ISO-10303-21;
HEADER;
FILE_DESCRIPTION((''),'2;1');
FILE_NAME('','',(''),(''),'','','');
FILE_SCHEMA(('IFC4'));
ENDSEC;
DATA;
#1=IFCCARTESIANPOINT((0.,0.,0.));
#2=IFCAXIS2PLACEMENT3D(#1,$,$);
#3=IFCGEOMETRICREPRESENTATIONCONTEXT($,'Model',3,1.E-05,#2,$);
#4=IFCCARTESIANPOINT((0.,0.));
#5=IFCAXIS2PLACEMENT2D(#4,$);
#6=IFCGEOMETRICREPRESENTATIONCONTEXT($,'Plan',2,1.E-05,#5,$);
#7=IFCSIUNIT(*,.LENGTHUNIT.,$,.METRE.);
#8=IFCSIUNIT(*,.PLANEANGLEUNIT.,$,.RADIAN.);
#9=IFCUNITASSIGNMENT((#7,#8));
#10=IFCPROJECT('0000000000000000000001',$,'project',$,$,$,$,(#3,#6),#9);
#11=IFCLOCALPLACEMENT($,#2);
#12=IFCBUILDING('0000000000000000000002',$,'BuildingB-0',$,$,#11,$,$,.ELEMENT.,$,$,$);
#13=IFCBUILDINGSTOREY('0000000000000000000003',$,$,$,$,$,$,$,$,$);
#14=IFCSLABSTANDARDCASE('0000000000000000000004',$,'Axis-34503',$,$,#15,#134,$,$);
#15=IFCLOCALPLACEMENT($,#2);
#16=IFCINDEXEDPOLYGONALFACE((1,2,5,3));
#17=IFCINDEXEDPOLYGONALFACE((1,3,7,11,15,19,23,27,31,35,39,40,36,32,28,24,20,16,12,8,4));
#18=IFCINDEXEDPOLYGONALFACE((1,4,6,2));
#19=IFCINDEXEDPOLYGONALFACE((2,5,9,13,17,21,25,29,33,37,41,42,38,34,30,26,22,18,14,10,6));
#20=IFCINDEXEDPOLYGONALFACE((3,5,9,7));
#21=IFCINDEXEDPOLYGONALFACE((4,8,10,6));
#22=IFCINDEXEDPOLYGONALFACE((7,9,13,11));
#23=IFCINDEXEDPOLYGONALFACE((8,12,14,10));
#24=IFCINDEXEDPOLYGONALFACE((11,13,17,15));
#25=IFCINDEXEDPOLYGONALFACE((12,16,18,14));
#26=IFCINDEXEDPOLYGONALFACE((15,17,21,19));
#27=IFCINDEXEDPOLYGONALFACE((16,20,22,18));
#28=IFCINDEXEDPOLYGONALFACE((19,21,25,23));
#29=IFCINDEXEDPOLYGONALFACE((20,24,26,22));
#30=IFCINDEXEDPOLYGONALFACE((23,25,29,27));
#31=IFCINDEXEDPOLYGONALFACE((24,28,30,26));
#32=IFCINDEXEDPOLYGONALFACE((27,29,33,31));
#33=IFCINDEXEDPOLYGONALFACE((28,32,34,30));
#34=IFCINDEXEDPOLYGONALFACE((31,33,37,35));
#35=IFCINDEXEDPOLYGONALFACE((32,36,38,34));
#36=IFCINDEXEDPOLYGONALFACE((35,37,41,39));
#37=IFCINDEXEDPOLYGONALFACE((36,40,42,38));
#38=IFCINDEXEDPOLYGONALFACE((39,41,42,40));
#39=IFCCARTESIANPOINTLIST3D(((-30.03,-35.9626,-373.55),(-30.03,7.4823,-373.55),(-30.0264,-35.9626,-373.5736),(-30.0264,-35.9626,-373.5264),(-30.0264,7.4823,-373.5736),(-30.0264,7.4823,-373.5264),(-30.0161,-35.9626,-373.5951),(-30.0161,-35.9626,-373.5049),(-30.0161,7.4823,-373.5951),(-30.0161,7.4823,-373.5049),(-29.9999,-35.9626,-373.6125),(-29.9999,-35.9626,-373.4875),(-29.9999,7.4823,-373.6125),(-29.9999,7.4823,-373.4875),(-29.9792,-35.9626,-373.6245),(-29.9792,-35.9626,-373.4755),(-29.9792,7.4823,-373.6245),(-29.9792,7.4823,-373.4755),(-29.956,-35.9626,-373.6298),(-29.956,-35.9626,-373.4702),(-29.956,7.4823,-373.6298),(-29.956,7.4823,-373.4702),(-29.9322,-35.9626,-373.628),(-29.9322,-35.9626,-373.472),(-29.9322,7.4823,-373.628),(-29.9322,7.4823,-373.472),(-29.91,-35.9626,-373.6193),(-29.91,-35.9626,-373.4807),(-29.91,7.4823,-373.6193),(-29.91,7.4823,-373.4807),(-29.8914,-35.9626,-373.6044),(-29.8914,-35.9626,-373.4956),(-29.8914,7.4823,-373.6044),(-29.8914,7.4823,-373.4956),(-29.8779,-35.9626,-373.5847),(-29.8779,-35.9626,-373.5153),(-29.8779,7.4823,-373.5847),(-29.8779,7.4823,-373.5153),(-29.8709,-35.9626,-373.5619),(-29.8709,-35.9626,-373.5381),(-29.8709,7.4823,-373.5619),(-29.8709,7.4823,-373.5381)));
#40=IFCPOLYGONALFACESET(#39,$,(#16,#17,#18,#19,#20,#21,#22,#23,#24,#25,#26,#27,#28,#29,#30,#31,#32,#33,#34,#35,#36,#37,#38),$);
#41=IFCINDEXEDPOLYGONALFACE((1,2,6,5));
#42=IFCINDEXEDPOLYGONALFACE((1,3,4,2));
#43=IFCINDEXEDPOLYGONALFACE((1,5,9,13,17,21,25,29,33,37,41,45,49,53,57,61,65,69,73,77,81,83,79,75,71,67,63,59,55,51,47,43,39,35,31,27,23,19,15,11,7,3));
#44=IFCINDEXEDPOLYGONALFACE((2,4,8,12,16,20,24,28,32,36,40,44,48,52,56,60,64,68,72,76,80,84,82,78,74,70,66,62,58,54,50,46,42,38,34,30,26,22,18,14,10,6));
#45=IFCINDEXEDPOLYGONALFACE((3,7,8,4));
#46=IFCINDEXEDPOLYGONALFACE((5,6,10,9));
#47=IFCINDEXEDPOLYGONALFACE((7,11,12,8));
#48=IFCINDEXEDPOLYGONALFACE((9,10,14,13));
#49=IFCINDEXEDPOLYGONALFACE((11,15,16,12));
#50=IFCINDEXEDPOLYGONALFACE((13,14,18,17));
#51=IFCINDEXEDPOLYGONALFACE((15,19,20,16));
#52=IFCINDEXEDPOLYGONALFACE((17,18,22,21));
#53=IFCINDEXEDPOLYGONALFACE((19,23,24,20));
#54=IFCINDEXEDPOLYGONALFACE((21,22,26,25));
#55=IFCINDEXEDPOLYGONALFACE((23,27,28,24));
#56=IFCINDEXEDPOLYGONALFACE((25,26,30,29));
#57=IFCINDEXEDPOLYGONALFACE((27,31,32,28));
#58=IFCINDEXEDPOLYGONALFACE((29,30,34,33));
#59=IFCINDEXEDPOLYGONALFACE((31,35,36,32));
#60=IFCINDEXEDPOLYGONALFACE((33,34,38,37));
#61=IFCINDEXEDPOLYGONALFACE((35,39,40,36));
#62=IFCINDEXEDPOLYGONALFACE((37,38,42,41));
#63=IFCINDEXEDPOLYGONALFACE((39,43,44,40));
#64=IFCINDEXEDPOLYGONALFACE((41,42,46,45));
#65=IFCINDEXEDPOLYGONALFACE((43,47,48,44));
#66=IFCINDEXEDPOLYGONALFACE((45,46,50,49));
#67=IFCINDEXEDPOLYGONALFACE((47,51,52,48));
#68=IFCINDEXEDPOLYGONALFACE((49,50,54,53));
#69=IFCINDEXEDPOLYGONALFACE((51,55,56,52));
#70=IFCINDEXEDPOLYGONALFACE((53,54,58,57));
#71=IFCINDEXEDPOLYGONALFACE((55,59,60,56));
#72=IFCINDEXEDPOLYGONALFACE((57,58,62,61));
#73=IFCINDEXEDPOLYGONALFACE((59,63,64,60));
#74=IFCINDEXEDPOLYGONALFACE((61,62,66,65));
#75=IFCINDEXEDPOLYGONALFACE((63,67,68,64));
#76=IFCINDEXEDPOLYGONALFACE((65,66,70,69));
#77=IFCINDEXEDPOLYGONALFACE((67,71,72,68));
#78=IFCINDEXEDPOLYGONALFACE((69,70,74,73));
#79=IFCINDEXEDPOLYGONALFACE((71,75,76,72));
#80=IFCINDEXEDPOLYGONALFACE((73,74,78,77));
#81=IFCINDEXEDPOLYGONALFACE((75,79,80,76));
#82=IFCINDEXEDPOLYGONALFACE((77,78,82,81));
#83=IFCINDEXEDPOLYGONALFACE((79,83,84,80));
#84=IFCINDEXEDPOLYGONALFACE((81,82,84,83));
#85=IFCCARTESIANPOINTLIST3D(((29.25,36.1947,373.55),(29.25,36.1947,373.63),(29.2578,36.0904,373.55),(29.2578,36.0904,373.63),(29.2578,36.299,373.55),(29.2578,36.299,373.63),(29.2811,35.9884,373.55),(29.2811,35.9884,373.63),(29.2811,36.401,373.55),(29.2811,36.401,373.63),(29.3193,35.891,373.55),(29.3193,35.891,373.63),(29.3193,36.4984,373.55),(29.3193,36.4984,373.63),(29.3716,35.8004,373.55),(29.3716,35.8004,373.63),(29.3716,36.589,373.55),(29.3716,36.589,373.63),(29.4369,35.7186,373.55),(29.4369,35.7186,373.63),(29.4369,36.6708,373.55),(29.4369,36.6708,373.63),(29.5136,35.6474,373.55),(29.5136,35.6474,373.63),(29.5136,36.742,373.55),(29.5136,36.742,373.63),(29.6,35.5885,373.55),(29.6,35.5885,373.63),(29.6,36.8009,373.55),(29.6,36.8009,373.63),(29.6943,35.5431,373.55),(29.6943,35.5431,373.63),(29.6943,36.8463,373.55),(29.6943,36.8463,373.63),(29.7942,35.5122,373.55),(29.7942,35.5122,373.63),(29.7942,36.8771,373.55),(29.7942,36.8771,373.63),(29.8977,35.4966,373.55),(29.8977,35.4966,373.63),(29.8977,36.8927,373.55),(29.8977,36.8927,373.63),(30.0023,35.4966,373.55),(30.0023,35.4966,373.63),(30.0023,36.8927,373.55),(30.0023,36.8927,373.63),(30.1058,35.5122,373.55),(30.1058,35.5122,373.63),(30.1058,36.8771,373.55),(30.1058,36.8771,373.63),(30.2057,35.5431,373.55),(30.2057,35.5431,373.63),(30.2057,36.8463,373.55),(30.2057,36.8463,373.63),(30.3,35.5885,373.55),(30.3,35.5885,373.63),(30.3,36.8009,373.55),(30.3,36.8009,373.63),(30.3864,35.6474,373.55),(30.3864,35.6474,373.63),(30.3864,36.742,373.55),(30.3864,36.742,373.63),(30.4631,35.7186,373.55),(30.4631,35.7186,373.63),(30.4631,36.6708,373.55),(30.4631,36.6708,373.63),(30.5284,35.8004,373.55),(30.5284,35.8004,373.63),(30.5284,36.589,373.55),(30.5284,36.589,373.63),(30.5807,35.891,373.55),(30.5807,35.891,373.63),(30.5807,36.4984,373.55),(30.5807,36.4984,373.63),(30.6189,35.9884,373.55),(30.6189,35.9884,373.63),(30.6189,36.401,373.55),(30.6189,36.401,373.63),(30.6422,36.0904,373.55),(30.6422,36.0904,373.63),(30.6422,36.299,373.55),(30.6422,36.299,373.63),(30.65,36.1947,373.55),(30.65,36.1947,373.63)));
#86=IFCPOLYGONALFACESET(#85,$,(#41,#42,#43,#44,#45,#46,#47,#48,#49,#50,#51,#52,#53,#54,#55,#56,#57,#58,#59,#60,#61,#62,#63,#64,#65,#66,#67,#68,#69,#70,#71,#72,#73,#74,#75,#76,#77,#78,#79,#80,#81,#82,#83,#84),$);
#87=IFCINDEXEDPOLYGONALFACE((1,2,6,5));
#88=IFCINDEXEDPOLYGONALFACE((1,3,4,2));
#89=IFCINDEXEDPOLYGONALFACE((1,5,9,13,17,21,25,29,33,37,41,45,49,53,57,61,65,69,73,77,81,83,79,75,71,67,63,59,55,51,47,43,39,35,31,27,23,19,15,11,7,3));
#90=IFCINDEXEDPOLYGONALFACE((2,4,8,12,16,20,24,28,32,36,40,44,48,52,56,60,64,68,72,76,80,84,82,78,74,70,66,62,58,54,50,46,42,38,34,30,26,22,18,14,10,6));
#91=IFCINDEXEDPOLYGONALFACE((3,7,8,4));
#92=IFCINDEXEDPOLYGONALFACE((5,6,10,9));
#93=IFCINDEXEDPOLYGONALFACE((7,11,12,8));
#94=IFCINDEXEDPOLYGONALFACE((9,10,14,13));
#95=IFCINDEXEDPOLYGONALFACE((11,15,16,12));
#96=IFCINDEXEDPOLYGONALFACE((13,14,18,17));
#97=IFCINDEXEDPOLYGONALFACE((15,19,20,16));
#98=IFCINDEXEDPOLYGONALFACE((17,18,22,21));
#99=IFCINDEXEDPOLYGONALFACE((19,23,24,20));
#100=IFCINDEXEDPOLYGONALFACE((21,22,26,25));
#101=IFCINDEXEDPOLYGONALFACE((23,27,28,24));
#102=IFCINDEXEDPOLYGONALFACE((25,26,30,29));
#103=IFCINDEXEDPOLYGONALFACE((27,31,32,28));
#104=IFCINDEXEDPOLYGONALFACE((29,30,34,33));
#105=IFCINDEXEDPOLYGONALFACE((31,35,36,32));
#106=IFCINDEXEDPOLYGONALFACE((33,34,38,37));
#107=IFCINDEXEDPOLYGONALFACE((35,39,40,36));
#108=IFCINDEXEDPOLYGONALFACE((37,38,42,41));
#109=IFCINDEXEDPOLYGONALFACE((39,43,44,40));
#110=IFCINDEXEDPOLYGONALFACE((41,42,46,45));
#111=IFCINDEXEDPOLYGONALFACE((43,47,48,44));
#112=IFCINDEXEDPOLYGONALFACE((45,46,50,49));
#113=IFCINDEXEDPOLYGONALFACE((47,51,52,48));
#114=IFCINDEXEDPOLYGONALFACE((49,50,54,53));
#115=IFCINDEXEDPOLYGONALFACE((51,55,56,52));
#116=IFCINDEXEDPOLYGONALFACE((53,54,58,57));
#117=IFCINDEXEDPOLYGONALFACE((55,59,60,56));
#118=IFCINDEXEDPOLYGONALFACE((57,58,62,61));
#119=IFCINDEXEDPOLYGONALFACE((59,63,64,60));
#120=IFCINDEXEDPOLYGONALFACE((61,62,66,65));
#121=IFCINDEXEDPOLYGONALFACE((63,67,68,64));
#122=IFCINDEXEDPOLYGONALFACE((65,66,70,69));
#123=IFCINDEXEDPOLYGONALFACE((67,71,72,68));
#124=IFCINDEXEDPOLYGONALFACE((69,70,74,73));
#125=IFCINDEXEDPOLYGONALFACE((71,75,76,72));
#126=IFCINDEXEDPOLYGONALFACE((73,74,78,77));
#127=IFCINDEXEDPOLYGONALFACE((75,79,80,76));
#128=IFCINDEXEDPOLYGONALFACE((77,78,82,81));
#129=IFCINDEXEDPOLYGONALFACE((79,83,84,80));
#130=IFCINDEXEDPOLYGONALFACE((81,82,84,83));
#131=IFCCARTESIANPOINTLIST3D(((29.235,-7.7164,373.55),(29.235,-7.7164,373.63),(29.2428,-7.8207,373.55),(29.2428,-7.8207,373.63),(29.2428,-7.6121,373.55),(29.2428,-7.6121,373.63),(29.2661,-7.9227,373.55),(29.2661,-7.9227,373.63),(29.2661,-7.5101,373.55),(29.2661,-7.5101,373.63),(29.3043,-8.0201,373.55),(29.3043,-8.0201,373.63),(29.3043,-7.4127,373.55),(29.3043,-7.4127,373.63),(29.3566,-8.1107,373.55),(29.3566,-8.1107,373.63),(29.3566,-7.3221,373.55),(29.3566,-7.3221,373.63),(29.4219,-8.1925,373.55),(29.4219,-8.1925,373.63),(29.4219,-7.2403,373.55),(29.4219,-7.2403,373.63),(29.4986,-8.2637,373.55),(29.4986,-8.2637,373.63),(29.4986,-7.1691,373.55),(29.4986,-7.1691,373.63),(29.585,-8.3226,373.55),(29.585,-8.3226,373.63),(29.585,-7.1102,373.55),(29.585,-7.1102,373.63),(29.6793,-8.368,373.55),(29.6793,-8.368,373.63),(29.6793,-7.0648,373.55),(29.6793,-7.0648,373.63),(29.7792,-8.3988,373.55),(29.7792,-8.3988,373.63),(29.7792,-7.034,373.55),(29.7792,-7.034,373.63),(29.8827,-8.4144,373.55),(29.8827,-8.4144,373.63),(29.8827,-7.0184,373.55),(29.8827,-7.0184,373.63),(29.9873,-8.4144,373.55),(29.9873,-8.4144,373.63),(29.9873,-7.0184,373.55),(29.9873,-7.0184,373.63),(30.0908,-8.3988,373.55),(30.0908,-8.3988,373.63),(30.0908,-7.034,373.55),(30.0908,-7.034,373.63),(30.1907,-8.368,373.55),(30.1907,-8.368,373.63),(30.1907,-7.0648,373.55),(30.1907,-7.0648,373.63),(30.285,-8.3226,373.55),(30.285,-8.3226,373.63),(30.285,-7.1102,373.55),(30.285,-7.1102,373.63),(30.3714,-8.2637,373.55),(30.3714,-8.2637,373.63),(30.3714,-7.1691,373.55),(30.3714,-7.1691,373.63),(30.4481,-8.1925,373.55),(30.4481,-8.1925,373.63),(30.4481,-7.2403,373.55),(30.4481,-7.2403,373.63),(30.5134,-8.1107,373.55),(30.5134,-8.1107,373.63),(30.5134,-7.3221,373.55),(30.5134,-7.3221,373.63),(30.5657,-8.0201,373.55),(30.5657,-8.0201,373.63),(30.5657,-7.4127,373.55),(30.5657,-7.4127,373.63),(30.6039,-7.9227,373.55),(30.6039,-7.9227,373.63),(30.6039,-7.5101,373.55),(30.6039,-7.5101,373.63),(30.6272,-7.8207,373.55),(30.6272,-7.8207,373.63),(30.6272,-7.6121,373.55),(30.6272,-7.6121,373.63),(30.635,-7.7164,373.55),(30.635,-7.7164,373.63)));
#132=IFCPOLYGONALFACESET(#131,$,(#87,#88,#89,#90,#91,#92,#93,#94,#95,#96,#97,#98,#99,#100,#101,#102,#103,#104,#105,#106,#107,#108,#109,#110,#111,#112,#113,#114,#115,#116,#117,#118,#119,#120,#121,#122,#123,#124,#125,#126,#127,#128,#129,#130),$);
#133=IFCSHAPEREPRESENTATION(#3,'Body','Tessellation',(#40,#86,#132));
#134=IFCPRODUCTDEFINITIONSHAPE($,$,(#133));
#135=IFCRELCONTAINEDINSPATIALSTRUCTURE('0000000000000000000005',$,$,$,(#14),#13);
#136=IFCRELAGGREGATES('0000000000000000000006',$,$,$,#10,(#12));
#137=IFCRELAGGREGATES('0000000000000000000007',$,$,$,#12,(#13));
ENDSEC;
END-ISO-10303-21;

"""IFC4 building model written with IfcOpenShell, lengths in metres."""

from ifc_helpers import new_model, entity, si_unit, frame, origin, origin_2d, place, context, project, spatial, circle, extrude, element, save


model = new_model("IFC4")

# Units and contexts
model_context = context("Model", 3, precision=1e-05, world=origin())
plan_context = context("Plan", 2, precision=1e-05, world=origin_2d())
ifc_project = project(units=[si_unit("LENGTHUNIT", "METRE"), si_unit("PLANEANGLEUNIT", "RADIAN")], contexts=[model_context, plan_context])

# Building, storey
building_placement = place(None, origin())
building = spatial("IfcBuilding", under=ifc_project, at=building_placement, Name="BuildingB-0", CompositionType="ELEMENT")
storey = spatial("IfcBuildingStorey", under=building)

# Slab
element("IfcSlabStandardCase", 1, inside=storey, Name="Axis-34503", context=model_context, shape_type="AdvancedSweptSolid", body=[
    entity("IfcSurfaceCurveSweptAreaSolid", entity("IfcCircleProfileDef", "AREA", None, None, 0.08), None, entity("IfcPolyline", [entity("IfcCartesianPoint", [29.95, 35.9626, 373.55]), entity("IfcCartesianPoint", [29.95, -7.4823, 373.55])]), None, None, entity("IfcPlane", entity("IfcAxis2Placement3D", entity("IfcCartesianPoint", [29.95, 35.9626, 373.55]), entity("IfcDirection", [0.0, 0.0, 1.0]), entity("IfcDirection", [1.0, 0.0, 0.0])))),
    extrude(circle(Radius=0.7), frame((29.95, 36.1947, 373.55)), (0.0, 0.0, 1.0), 0.08),
    extrude(circle(Radius=0.7), frame((29.935, -7.7164, 373.55)), (0.0, 0.0, 1.0), 0.08),
])

save(model, "model.ifc")
